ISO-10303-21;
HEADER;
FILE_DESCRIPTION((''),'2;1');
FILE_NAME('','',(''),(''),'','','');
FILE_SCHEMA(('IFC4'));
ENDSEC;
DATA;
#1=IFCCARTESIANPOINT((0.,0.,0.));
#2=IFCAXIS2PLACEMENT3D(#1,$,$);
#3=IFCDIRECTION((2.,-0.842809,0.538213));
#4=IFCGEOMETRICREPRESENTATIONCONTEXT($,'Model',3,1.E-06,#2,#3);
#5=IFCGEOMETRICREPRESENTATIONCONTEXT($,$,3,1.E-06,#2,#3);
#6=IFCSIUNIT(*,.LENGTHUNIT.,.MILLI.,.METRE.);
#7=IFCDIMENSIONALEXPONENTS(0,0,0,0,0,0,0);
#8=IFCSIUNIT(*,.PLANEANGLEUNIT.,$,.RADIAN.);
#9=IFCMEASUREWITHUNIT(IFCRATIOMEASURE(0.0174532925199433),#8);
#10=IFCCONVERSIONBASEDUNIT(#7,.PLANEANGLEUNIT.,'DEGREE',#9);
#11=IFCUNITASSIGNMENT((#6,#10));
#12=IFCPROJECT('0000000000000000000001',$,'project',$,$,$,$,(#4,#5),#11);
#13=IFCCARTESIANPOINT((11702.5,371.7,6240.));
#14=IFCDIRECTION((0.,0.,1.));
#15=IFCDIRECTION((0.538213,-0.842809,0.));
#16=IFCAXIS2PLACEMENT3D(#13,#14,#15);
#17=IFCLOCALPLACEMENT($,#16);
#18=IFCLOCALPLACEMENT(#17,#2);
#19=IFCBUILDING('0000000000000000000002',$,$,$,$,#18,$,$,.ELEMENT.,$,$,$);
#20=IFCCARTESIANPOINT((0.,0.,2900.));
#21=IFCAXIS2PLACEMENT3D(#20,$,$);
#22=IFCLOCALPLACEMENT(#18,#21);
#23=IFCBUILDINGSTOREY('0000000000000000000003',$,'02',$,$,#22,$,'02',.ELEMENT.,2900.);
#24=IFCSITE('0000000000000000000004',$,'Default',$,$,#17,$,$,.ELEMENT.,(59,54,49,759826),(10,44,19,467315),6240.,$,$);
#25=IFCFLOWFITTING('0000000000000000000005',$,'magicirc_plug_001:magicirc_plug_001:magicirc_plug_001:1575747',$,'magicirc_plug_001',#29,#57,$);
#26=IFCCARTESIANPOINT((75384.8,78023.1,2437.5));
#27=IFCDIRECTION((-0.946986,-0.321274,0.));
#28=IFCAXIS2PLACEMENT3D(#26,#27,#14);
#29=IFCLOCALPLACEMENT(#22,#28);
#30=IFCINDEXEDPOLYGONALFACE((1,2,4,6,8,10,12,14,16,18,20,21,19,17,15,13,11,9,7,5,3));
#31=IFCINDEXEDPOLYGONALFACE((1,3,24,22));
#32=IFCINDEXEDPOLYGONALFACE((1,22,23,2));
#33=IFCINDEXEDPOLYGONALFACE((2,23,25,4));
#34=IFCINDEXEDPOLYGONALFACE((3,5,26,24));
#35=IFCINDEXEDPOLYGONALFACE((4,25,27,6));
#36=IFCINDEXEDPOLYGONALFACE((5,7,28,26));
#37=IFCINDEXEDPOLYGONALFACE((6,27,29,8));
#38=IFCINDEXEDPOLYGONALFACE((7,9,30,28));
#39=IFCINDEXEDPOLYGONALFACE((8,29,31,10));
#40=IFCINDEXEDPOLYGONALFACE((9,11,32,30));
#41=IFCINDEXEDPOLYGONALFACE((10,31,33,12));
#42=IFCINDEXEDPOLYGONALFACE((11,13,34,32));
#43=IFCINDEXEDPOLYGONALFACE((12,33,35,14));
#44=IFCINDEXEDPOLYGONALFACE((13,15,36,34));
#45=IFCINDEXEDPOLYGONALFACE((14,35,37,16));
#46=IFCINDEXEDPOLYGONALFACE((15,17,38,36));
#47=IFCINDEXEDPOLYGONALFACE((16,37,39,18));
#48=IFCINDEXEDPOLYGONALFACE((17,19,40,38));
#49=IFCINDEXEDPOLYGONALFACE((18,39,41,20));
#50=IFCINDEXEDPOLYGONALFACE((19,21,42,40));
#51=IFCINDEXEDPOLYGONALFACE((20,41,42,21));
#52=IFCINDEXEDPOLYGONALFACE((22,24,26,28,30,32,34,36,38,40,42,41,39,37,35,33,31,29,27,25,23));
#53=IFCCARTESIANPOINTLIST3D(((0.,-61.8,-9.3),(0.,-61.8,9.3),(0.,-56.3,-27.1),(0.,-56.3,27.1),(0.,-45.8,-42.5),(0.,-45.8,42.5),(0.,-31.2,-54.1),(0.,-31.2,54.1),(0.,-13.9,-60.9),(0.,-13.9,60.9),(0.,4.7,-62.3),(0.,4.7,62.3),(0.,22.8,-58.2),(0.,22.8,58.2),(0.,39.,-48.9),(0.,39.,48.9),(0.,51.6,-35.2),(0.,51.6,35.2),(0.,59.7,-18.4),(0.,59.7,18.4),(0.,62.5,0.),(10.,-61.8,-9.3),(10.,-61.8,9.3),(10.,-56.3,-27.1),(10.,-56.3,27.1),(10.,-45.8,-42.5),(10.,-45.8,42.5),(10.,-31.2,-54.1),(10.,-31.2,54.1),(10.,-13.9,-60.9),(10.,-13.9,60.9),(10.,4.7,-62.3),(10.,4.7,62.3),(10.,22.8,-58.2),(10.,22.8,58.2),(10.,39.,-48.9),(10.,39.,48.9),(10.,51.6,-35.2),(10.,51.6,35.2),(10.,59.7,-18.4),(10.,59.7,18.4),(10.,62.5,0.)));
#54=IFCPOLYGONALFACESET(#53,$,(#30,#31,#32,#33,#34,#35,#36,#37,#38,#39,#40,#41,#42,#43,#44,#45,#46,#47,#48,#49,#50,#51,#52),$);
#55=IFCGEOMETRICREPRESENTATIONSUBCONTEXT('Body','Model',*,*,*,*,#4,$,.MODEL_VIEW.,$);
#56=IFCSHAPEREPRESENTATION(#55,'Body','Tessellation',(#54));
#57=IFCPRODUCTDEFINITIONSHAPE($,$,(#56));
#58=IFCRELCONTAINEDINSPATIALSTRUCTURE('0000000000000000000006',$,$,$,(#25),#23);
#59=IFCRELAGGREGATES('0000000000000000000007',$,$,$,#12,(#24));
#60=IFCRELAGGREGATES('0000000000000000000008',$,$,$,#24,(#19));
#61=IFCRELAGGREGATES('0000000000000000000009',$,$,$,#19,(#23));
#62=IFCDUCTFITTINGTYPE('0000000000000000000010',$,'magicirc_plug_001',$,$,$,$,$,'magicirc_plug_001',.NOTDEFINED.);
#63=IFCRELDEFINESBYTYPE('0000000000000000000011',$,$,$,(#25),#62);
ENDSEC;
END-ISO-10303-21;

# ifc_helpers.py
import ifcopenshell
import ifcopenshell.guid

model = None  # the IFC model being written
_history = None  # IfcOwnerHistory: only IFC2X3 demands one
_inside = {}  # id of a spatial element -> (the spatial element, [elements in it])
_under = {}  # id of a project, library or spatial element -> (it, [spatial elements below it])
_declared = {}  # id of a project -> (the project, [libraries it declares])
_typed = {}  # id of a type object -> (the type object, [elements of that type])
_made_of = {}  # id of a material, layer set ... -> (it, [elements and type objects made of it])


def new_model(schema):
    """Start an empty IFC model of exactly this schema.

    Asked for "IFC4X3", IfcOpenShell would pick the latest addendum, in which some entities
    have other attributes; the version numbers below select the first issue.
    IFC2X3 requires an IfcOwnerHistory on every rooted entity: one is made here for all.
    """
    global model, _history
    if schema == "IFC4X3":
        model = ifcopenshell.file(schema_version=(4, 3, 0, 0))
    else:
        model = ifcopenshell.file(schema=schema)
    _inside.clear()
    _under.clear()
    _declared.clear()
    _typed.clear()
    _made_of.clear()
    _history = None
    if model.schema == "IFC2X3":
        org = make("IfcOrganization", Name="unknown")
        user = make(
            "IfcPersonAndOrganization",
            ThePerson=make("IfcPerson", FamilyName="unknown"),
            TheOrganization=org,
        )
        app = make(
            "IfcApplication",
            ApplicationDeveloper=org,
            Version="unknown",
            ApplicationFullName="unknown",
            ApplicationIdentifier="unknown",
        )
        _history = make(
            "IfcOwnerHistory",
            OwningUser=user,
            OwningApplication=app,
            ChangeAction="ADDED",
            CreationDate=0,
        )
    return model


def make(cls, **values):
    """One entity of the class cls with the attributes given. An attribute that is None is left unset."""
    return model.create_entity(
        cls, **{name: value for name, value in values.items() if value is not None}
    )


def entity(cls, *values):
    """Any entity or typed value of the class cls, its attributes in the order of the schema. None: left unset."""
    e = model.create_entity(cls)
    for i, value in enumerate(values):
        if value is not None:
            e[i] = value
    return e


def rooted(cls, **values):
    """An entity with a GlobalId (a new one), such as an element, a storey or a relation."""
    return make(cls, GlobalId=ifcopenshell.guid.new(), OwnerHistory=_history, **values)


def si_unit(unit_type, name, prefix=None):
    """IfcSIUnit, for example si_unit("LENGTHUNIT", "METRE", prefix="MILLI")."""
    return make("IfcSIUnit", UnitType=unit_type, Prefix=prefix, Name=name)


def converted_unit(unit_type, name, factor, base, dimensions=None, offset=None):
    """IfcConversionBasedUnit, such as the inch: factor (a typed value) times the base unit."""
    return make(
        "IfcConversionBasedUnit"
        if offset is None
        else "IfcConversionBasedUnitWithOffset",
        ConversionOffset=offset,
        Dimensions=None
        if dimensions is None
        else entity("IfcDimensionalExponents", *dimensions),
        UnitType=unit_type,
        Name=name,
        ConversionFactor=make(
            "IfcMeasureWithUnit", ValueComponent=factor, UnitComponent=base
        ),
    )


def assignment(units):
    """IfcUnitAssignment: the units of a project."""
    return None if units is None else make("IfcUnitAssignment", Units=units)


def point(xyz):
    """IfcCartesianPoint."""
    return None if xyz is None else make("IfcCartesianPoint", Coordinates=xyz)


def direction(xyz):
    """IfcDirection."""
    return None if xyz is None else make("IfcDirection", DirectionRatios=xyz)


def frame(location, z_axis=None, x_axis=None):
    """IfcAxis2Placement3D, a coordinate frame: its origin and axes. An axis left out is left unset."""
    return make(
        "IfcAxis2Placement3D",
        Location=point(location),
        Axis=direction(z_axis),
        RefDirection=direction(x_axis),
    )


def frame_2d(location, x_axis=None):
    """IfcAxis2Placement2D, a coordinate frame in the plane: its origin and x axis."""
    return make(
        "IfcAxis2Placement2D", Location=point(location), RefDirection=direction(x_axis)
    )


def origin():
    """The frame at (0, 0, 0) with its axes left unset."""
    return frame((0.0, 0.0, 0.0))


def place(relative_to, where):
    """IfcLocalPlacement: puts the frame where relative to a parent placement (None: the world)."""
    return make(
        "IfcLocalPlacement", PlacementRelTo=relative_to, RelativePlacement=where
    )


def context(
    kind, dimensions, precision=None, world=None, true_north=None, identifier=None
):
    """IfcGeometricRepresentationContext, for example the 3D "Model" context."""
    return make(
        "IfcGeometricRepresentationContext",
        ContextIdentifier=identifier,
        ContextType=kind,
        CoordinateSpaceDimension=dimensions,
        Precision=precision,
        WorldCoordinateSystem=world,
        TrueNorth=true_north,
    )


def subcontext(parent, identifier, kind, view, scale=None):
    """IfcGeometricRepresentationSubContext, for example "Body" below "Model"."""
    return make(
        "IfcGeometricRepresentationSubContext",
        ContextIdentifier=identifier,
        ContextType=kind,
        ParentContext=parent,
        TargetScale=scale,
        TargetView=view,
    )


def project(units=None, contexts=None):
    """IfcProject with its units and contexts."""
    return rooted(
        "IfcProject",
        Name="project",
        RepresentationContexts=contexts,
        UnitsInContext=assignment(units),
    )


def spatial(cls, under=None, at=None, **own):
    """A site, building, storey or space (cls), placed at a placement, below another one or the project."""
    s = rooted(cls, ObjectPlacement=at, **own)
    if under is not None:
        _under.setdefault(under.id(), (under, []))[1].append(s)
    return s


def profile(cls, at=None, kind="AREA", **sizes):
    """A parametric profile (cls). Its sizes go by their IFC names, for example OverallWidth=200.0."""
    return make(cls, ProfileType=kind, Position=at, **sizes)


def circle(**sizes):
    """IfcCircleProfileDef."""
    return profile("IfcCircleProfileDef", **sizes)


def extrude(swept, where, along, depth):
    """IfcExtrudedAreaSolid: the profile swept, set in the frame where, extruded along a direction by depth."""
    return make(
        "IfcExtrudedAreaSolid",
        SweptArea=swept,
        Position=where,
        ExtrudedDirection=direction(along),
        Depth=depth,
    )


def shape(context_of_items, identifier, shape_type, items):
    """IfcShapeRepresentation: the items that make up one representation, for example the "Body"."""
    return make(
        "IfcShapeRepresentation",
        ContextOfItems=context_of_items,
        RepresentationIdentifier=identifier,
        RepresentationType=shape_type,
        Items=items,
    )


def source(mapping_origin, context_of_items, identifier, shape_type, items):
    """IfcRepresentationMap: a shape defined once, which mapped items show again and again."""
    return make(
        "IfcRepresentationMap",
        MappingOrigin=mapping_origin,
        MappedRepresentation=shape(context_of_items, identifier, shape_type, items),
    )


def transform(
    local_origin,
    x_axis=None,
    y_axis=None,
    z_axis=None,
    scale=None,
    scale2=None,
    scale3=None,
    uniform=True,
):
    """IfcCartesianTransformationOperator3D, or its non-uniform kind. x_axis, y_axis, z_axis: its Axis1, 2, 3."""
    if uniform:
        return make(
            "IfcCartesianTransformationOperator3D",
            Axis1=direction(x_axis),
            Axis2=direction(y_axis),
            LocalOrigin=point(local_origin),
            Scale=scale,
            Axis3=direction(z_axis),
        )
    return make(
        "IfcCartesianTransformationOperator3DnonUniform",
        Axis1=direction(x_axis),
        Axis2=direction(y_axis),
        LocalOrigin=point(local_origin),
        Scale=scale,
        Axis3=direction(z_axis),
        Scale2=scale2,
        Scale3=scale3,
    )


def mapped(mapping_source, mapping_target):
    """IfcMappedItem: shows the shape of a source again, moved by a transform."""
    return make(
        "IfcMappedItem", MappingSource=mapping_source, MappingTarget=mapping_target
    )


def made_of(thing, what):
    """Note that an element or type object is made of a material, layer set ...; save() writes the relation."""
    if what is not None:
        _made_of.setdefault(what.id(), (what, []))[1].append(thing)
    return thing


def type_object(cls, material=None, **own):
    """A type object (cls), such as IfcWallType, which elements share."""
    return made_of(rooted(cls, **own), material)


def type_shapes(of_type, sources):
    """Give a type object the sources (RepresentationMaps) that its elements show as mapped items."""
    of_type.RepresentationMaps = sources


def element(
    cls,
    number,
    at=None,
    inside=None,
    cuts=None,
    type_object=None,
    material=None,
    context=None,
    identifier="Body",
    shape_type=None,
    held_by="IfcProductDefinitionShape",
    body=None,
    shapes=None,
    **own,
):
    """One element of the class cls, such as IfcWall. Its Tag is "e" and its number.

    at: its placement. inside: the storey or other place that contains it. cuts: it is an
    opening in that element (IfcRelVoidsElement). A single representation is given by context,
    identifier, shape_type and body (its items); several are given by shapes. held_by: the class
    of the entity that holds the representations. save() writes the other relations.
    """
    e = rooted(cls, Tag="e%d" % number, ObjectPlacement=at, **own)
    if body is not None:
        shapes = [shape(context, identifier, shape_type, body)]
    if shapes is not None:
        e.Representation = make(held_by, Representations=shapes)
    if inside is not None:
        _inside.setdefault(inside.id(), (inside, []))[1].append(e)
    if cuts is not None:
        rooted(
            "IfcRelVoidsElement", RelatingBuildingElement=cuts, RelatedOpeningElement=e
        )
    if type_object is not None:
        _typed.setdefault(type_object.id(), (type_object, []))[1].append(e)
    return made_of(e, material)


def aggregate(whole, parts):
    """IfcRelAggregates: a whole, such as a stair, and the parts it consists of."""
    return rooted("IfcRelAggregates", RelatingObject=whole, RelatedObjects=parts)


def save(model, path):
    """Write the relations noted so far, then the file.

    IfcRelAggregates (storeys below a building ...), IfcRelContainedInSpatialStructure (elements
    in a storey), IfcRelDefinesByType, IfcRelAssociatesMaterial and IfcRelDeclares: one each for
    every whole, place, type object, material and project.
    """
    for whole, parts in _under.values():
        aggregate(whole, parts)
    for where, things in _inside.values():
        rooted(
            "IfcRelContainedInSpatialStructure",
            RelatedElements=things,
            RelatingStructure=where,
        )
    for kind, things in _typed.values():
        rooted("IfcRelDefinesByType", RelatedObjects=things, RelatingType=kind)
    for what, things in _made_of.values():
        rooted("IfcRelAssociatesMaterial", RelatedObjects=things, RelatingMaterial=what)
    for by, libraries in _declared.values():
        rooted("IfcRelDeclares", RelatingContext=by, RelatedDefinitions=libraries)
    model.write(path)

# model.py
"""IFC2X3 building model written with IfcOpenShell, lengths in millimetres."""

from ifc_helpers import new_model, entity, si_unit, converted_unit, direction, frame, frame_2d, origin, place, context, subcontext, project, spatial, circle, extrude, source, transform, mapped, type_object, type_shapes, element, save


model = new_model("IFC2X3")

# Units and contexts
model_context = context("Model", 3, precision=1e-06, world=origin(), true_north=direction((2.0, -0.842809, 0.538213)))
context_of_model = context(None, 3, precision=1e-06, world=origin(), true_north=direction((2.0, -0.842809, 0.538213)))
body_context = subcontext(model_context, "Body", "Model", "MODEL_VIEW")
ifc_project = project(units=[si_unit("LENGTHUNIT", "METRE", prefix="MILLI"), converted_unit("PLANEANGLEUNIT", "DEGREE", entity("IfcRatioMeasure", 0.0174532925199433), si_unit("PLANEANGLEUNIT", "RADIAN"), dimensions=[0, 0, 0, 0, 0, 0, 0])], contexts=[model_context, context_of_model])

# Site, building, storey
site_placement = place(None, frame((11702.5, 371.7, 6240.0), z_axis=(0.0, 0.0, 1.0), x_axis=(0.538213, -0.842809, 0.0)))
site = spatial("IfcSite", under=ifc_project, at=site_placement, Name="Default", CompositionType="ELEMENT", RefLatitude=(59, 54, 49, 759826), RefLongitude=(10, 44, 19, 467315), RefElevation=6240.0)
building_placement = place(site_placement, origin())
building = spatial("IfcBuilding", under=site, at=building_placement, CompositionType="ELEMENT")
storey_placement = place(building_placement, frame((0.0, 0.0, 2900.0)))
storey = spatial("IfcBuildingStorey", under=building, at=storey_placement, Name="02", LongName="02", CompositionType="ELEMENT", Elevation=2900.0)

# Flow fitting
duct_fitting_type_1 = type_object("IfcDuctFittingType", Name="magicirc_plug_001", ElementType="magicirc_plug_001", PredefinedType="NOTDEFINED")
shared_shape_1 = source(origin(), body_context, "Body", "SweptSolid", [
    extrude(circle(Radius=62.5, at=frame_2d((0.0, 0.0), x_axis=(1.0, 0.0))), frame((0.0, 0.0, 0.0), z_axis=(1.0, 0.0, 0.0), x_axis=(0.0, 1.0, 0.0)), (0.0, 0.0, 1.0), 10.0),
])
type_shapes(duct_fitting_type_1, [shared_shape_1])
for number, where, z_axis, x_axis, name in (
    (1, (75384.8, 78023.1, 2437.5), (-0.946986, -0.321274, 0.0), (0.0, 0.0, 1.0), "magicirc_plug_001:magicirc_plug_001:magicirc_plug_001:1575747"),
):
    element("IfcFlowFitting", number, at=place(storey_placement, frame(where, z_axis=z_axis, x_axis=x_axis)), inside=storey, type_object=duct_fitting_type_1, Name=name, ObjectType="magicirc_plug_001", context=body_context, shape_type="MappedRepresentation", body=[
        mapped(shared_shape_1, transform((0.0, 0.0, 0.0), scale=1.0)),
    ])

save(model, "model.ifc")
